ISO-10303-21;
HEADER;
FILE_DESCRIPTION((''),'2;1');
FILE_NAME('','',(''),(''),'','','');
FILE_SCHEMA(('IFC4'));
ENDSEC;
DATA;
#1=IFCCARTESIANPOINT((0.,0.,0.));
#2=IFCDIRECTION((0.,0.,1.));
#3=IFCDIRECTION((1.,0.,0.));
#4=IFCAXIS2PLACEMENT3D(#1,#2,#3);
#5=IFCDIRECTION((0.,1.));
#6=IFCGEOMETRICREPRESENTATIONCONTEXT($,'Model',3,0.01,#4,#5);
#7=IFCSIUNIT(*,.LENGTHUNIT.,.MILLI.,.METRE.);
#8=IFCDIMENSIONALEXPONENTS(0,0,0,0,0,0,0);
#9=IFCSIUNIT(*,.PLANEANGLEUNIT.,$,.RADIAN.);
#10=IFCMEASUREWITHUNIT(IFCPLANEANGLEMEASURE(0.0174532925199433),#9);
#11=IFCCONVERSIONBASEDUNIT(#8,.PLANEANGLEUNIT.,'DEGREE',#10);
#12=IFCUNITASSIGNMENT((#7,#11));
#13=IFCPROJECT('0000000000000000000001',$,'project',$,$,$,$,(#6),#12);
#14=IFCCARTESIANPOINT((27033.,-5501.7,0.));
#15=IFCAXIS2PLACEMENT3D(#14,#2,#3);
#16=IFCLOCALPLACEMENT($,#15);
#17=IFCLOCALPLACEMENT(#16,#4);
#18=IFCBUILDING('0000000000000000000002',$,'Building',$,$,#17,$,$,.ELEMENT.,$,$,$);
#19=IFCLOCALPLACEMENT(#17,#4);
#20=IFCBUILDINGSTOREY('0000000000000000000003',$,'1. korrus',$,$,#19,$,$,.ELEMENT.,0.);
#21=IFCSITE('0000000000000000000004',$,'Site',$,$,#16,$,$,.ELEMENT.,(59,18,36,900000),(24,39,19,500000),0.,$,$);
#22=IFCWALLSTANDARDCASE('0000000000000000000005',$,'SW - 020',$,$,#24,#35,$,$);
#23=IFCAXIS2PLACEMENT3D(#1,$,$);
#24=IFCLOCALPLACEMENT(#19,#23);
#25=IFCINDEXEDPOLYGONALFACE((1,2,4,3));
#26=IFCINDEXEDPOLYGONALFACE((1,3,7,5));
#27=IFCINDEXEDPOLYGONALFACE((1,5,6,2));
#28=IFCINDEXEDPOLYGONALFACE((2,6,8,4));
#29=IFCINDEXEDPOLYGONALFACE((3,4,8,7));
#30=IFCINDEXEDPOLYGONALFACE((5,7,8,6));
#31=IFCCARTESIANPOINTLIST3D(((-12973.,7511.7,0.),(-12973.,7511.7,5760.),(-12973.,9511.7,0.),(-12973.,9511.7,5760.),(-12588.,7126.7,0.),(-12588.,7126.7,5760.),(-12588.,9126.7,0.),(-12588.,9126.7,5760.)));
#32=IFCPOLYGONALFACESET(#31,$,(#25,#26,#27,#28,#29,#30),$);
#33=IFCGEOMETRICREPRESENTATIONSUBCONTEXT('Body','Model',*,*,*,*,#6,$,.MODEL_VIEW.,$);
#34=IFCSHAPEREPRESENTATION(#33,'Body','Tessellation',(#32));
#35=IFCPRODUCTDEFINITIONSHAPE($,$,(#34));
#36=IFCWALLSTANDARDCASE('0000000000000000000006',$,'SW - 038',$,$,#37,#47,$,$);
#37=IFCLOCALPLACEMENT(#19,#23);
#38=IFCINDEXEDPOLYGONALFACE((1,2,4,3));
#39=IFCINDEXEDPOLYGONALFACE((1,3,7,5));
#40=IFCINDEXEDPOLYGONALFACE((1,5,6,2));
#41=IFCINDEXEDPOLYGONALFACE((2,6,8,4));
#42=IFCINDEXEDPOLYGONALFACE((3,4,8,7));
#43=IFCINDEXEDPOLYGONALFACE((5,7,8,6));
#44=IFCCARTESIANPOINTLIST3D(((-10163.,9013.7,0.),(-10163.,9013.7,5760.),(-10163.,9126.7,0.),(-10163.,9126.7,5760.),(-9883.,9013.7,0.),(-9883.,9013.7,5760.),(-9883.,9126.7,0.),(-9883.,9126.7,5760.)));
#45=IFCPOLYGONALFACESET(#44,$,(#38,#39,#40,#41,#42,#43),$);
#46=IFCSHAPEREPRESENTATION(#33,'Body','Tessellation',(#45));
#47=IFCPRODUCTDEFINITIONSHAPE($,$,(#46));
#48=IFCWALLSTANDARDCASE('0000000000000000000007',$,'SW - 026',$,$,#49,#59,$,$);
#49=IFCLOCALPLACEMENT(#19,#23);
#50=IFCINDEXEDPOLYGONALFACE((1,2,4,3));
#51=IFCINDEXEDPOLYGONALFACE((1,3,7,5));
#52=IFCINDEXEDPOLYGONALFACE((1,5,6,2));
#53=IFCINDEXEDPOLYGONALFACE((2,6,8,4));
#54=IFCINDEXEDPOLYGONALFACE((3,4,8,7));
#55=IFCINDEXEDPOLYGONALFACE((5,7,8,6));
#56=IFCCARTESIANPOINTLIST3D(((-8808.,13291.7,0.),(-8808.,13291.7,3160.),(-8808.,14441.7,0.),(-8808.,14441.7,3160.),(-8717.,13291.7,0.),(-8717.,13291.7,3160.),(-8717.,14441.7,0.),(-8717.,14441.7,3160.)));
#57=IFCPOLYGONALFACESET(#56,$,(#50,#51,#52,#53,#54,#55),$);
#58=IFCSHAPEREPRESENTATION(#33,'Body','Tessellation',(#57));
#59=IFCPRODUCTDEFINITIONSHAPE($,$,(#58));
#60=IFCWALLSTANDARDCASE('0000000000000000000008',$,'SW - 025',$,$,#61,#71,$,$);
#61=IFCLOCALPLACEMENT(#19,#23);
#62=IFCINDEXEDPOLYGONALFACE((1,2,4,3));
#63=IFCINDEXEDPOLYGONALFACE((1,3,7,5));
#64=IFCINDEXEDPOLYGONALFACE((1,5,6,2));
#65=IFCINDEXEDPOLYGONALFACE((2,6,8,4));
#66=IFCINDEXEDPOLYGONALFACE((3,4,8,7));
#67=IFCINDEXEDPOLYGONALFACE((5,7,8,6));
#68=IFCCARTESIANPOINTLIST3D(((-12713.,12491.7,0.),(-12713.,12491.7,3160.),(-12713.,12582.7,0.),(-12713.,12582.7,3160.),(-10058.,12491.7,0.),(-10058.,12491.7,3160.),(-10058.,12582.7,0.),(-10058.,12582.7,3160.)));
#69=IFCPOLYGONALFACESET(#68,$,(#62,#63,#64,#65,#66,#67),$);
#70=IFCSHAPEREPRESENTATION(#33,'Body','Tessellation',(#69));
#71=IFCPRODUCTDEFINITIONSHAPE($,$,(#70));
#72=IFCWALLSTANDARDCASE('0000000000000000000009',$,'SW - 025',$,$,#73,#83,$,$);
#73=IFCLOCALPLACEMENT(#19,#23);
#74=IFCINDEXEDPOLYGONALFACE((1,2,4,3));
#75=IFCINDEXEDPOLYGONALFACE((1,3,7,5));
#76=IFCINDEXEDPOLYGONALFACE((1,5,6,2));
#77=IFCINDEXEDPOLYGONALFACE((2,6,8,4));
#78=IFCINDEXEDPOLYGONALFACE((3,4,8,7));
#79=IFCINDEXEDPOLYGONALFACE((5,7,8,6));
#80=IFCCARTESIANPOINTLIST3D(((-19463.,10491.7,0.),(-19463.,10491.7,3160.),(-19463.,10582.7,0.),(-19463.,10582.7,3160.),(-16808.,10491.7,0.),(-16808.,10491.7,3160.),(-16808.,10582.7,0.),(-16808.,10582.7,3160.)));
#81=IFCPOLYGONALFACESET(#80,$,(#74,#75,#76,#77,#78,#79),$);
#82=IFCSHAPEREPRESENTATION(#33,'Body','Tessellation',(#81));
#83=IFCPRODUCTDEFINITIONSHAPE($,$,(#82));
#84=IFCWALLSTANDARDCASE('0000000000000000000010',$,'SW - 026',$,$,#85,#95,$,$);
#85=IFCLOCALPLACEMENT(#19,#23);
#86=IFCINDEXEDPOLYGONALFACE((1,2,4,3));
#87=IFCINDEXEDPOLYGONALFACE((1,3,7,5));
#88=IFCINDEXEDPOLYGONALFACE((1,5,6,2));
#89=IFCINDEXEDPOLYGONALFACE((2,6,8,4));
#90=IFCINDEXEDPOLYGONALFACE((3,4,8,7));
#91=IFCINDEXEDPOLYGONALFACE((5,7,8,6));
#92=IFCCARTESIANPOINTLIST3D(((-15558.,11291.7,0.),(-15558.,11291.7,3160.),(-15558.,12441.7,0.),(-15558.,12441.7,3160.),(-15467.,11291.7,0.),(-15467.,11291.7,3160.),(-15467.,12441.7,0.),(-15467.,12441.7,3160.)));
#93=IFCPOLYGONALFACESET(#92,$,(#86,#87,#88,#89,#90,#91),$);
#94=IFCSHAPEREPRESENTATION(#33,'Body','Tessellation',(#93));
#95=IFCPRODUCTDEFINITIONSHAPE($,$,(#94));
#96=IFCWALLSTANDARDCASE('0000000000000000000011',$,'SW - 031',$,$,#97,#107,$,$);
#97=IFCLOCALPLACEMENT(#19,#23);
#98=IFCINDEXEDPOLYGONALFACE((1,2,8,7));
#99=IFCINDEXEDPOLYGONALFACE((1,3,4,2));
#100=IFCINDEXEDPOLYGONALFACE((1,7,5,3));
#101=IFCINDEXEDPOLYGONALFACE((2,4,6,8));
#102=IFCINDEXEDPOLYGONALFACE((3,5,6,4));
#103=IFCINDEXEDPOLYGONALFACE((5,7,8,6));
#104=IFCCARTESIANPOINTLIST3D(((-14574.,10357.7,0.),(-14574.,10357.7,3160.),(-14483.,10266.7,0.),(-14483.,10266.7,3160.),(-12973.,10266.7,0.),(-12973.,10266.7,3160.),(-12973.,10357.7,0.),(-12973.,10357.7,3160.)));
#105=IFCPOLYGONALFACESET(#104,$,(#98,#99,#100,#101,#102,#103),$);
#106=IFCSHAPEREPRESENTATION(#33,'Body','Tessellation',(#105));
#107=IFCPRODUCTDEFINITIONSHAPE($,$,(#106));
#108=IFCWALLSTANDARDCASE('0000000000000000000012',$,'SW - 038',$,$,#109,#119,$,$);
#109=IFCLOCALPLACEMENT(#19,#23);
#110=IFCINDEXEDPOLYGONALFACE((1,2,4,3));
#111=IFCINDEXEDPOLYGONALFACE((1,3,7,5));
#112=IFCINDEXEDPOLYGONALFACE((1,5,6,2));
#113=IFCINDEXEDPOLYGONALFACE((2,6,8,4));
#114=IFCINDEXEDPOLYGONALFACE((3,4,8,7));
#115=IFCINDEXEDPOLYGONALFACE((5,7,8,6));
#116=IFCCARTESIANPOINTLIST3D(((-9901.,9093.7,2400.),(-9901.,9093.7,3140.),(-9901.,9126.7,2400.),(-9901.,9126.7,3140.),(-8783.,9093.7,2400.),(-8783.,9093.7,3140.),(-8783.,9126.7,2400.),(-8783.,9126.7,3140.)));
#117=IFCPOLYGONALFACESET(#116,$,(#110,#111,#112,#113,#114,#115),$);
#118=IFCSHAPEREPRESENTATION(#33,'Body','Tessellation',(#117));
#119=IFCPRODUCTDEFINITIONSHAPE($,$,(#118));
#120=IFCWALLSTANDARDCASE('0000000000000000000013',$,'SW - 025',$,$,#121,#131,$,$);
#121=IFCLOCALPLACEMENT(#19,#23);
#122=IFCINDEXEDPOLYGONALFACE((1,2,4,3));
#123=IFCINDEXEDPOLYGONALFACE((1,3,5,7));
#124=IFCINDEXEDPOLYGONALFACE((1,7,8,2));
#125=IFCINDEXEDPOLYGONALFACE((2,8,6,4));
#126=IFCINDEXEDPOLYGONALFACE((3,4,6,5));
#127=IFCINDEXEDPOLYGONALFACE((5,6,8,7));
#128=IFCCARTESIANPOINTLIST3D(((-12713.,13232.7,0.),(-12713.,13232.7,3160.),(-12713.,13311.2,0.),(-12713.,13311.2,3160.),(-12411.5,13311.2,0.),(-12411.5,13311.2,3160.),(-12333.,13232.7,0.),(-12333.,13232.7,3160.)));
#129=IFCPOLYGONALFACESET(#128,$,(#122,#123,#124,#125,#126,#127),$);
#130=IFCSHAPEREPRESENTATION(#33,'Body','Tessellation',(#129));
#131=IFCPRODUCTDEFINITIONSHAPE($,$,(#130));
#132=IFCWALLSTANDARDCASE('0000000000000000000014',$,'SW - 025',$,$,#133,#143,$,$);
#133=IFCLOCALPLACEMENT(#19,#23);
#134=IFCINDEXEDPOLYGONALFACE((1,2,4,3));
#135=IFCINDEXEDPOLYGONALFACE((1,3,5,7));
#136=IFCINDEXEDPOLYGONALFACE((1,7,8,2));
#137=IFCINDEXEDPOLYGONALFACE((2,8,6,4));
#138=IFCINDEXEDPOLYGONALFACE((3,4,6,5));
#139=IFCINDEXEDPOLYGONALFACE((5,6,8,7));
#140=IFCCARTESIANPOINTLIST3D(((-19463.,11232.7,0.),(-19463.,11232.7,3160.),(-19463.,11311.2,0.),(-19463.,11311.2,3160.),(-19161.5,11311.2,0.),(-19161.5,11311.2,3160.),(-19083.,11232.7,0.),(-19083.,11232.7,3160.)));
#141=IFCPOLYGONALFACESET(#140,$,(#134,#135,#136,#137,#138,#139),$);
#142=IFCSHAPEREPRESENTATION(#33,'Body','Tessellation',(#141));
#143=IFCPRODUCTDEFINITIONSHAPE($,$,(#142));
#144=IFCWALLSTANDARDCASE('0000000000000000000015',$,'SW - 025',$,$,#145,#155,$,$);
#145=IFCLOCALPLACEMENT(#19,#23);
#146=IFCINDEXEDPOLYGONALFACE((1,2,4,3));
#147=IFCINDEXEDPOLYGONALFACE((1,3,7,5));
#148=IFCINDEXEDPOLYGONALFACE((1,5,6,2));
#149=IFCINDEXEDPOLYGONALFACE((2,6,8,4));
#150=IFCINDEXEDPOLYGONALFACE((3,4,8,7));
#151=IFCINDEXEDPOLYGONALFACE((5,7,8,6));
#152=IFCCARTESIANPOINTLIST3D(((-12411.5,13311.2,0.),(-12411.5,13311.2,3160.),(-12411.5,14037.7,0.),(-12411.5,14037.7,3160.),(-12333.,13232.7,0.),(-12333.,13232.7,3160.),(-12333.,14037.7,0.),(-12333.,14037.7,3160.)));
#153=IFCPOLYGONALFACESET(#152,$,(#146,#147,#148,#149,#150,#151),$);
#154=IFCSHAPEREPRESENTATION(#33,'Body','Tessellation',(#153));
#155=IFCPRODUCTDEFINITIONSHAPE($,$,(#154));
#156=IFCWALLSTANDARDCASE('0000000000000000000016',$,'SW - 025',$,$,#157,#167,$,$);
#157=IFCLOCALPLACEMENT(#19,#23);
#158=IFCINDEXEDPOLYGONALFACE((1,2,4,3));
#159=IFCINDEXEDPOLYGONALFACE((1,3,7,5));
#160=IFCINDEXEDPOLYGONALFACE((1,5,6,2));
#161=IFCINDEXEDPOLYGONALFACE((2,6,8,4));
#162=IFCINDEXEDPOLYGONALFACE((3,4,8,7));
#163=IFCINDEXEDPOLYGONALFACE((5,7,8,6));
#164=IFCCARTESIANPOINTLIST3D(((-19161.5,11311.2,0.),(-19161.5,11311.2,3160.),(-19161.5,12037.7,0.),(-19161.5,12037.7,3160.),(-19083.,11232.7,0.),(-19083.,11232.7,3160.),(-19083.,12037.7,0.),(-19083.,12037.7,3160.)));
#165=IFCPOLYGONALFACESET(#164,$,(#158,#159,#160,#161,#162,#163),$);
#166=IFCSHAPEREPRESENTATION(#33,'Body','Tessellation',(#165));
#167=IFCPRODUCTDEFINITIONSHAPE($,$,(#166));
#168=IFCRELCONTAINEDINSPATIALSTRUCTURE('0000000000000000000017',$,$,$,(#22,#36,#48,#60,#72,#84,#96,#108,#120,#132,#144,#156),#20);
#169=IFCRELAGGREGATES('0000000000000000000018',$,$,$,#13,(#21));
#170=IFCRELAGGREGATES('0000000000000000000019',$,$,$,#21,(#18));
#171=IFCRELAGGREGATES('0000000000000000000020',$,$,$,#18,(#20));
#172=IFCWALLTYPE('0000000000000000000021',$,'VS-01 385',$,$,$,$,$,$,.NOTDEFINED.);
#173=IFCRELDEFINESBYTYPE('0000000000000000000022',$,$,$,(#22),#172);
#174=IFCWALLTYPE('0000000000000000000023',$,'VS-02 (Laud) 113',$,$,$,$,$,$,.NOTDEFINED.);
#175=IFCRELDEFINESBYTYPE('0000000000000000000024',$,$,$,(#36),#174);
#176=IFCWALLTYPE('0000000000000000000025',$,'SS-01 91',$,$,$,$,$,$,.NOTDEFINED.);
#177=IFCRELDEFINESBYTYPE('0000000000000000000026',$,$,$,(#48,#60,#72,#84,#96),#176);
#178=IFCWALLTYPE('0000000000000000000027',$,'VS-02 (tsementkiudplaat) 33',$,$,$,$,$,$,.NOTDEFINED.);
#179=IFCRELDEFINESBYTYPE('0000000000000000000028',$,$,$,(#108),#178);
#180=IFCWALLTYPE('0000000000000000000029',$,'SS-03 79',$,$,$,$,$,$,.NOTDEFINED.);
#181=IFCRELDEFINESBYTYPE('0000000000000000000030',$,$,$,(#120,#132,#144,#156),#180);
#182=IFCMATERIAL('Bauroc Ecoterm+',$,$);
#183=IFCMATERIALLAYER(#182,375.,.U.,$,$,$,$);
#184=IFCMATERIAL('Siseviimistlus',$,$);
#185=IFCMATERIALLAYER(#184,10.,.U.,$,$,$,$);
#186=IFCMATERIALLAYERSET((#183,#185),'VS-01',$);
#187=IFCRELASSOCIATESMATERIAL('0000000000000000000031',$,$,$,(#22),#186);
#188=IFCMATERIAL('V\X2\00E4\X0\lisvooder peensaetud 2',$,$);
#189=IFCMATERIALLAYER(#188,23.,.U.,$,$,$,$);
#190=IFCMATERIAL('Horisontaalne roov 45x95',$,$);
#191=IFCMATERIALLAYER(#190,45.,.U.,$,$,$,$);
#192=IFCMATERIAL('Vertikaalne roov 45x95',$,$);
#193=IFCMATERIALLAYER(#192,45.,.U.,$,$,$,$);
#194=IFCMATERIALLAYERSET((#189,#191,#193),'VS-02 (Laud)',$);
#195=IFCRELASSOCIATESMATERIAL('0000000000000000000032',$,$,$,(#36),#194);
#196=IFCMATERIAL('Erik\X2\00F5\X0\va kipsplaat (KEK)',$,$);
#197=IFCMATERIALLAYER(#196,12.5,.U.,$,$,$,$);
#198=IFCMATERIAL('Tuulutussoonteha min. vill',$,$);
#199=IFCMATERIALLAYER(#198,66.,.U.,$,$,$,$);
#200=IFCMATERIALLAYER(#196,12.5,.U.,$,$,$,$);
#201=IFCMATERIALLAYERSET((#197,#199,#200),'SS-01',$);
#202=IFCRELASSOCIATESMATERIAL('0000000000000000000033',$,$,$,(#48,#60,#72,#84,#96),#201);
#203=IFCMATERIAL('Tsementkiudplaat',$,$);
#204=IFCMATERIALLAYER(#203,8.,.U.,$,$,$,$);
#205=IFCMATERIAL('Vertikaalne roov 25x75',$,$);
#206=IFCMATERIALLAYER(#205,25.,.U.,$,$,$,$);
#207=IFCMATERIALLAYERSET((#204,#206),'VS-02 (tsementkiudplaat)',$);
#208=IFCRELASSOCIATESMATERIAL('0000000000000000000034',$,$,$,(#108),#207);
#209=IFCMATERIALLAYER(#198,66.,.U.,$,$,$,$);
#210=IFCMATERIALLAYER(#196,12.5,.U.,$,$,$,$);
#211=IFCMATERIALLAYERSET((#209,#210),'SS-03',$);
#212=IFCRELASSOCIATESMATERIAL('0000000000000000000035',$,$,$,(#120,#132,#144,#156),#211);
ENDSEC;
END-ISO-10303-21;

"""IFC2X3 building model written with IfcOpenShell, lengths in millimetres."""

from ifc_helpers import new_model, entity, si_unit, converted_unit, direction, frame, origin_with_axes, origin_2d_with_axis, place, context, subcontext, project, spatial, polyline, rectangle, outline, extrude, material, layer, layer_set, layer_usage, type_object, element, save


model = new_model("IFC2X3")

# Units and contexts
model_context = context("Model", 3, precision=0.01, world=origin_with_axes(), true_north=direction((0.0, 1.0)))
body_context = subcontext(model_context, "Body", "Model", "MODEL_VIEW")
ifc_project = project(units=[si_unit("LENGTHUNIT", "METRE", prefix="MILLI"), converted_unit("PLANEANGLEUNIT", "DEGREE", entity("IfcPlaneAngleMeasure", 0.0174532925199433), si_unit("PLANEANGLEUNIT", "RADIAN"), dimensions=[0, 0, 0, 0, 0, 0, 0])], contexts=[model_context])

# Site, building, storey
site_placement = place(None, frame((27033.0, -5501.7, 0.0), z_axis=(0.0, 0.0, 1.0), x_axis=(1.0, 0.0, 0.0)))
site = spatial("IfcSite", under=ifc_project, at=site_placement, Name="Site", CompositionType="ELEMENT", RefLatitude=(59, 18, 36, 900000), RefLongitude=(24, 39, 19, 500000), RefElevation=0.0)
building_placement = place(site_placement, origin_with_axes())
building = spatial("IfcBuilding", under=site, at=building_placement, Name="Building", CompositionType="ELEMENT")
storey_placement = place(building_placement, origin_with_axes())
storey = spatial("IfcBuildingStorey", under=building, at=storey_placement, Name="1. korrus", CompositionType="ELEMENT", Elevation=0.0)

# Walls
ifc_material_1 = material(Name="Bauroc Ecoterm+")
ifc_layer_1 = layer(ifc_material_1, 375.0, ventilated="UNKNOWN")
ifc_material_2 = material(Name="Siseviimistlus")
ifc_layer_2 = layer(ifc_material_2, 10.0, ventilated="UNKNOWN")
ifc_layer_set_1 = layer_set([ifc_layer_1, ifc_layer_2], Name="VS-01")
ifc_layer_usage_1 = layer_usage(ifc_layer_set_1, "AXIS2", "NEGATIVE", 385.0)
wall_type_1 = type_object("IfcWallType", Name="VS-01 385", PredefinedType="NOTDEFINED")
wall_1_placement = place(storey_placement, frame((-12973.0, 9511.7, 0.0), z_axis=(0.0, 0.0, 1.0), x_axis=(0.0, -1.0, 0.0)))
element("IfcWallStandardCase", 1, at=wall_1_placement, inside=storey, type_object=wall_type_1, material=ifc_layer_usage_1, Name="SW - 020", context=body_context, shape_type="SweptSolid", body=[
    extrude(outline(polyline([(0.0, 0.0), (2000.0, 0.0), (2385.0, 385.0), (385.0, 385.0), (0.0, 0.0)])), origin_with_axes(), (0.0, 0.0, 1.0), 5760.0),
])
ifc_material_3 = material(Name="Välisvooder peensaetud 2")
ifc_layer_3 = layer(ifc_material_3, 23.0, ventilated="UNKNOWN")
ifc_material_4 = material(Name="Horisontaalne roov 45x95")
ifc_layer_4 = layer(ifc_material_4, 45.0, ventilated="UNKNOWN")
ifc_material_5 = material(Name="Vertikaalne roov 45x95")
ifc_layer_5 = layer(ifc_material_5, 45.0, ventilated="UNKNOWN")
ifc_layer_set_2 = layer_set([ifc_layer_3, ifc_layer_4, ifc_layer_5], Name="VS-02 (Laud)")
wall_type_2 = type_object("IfcWallType", Name="VS-02 (Laud) 113", PredefinedType="NOTDEFINED")
ifc_layer_usage_2 = layer_usage(ifc_layer_set_2, "AXIS2", "POSITIVE", -113.0)
wall_2_placement = place(storey_placement, frame((-10163.0, 9126.7, 0.0), z_axis=(0.0, 0.0, 1.0), x_axis=(1.0, 0.0, 0.0)))
element("IfcWallStandardCase", 2, at=wall_2_placement, inside=storey, type_object=wall_type_2, material=ifc_layer_usage_2, Name="SW - 038", context=body_context, shape_type="SweptSolid", body=[
    extrude(outline(polyline([(0.0, -113.0), (280.0, -113.0), (280.0, 0.0), (0.0, 0.0), (0.0, -113.0)])), origin_with_axes(), (0.0, 0.0, 1.0), 5760.0),
])
ifc_material_6 = material(Name="Erikõva kipsplaat (KEK)")
ifc_layer_6 = layer(ifc_material_6, 12.5, ventilated="UNKNOWN")
ifc_material_7 = material(Name="Tuulutussoonteha min. vill")
ifc_layer_7 = layer(ifc_material_7, 66.0, ventilated="UNKNOWN")
ifc_layer_8 = layer(ifc_material_6, 12.5, ventilated="UNKNOWN")
ifc_layer_set_3 = layer_set([ifc_layer_6, ifc_layer_7, ifc_layer_8], Name="SS-01")
ifc_layer_usage_3 = layer_usage(ifc_layer_set_3, "AXIS2", "POSITIVE", -91.0)
wall_type_3 = type_object("IfcWallType", Name="SS-01 91", PredefinedType="NOTDEFINED")
wall_3_placement = place(storey_placement, frame((-8808.0, 13291.7, 0.0), z_axis=(0.0, 0.0, 1.0), x_axis=(0.0, 1.0, 0.0)))
element("IfcWallStandardCase", 3, at=wall_3_placement, inside=storey, type_object=wall_type_3, material=ifc_layer_usage_3, Name="SW - 026", context=body_context, shape_type="SweptSolid", body=[
    extrude(outline(polyline([(0.0, -91.0), (1150.0, -91.0), (1150.0, 0.0), (0.0, 0.0), (0.0, -91.0)])), origin_with_axes(), (0.0, 0.0, 1.0), 3160.0),
])
ifc_layer_usage_4 = layer_usage(ifc_layer_set_3, "AXIS2", "NEGATIVE", 91.0)
wall_4_placement = place(storey_placement, frame((-12713.0, 12491.7, 0.0), z_axis=(0.0, 0.0, 1.0), x_axis=(1.0, 0.0, 0.0)))
element("IfcWallStandardCase", 4, at=wall_4_placement, inside=storey, type_object=wall_type_3, material=ifc_layer_usage_4, Name="SW - 025", context=body_context, shape_type="SweptSolid", body=[
    extrude(outline(polyline([(0.0, 0.0), (2655.0, 0.0), (2655.0, 91.0), (0.0, 91.0), (0.0, 0.0)])), origin_with_axes(), (0.0, 0.0, 1.0), 3160.0),
])

# Walls
ifc_layer_usage_5 = layer_usage(ifc_layer_set_3, "AXIS2", "NEGATIVE", 91.0)
wall_5_placement = place(storey_placement, frame((-19463.0, 10491.7, 0.0), z_axis=(0.0, 0.0, 1.0), x_axis=(1.0, 0.0, 0.0)))
element("IfcWallStandardCase", 5, at=wall_5_placement, inside=storey, type_object=wall_type_3, material=ifc_layer_usage_5, Name="SW - 025", context=body_context, shape_type="SweptSolid", body=[
    extrude(outline(polyline([(0.0, 0.0), (2655.0, 0.0), (2655.0, 91.0), (0.0, 91.0), (0.0, 0.0)])), origin_with_axes(), (0.0, 0.0, 1.0), 3160.0),
])
ifc_layer_usage_6 = layer_usage(ifc_layer_set_3, "AXIS2", "POSITIVE", -91.0)
wall_6_placement = place(storey_placement, frame((-15558.0, 11291.7, 0.0), z_axis=(0.0, 0.0, 1.0), x_axis=(0.0, 1.0, 0.0)))
element("IfcWallStandardCase", 6, at=wall_6_placement, inside=storey, type_object=wall_type_3, material=ifc_layer_usage_6, Name="SW - 026", context=body_context, shape_type="SweptSolid", body=[
    extrude(outline(polyline([(0.0, -91.0), (1150.0, -91.0), (1150.0, 0.0), (0.0, 0.0), (0.0, -91.0)])), origin_with_axes(), (0.0, 0.0, 1.0), 3160.0),
])
ifc_layer_usage_7 = layer_usage(ifc_layer_set_3, "AXIS2", "NEGATIVE", 91.0)
wall_7_placement = place(storey_placement, frame((-12973.0, 10357.7, 0.0), z_axis=(0.0, 0.0, 1.0), x_axis=(-1.0, 0.0, 0.0)))
element("IfcWallStandardCase", 7, at=wall_7_placement, inside=storey, type_object=wall_type_3, material=ifc_layer_usage_7, Name="SW - 031", context=body_context, shape_type="SweptSolid", body=[
    extrude(outline(polyline([(0.0, 0.0), (1601.0, 0.0), (1510.0, 91.0), (0.0, 91.0), (0.0, 0.0)])), origin_with_axes(), (0.0, 0.0, 1.0), 3160.0),
])

# Shared definitions
ifc_material_8 = material(Name="Tsementkiudplaat")
ifc_layer_9 = layer(ifc_material_8, 8.0, ventilated="UNKNOWN")
ifc_material_9 = material(Name="Vertikaalne roov 25x75")
ifc_layer_10 = layer(ifc_material_9, 25.0, ventilated="UNKNOWN")
ifc_layer_set_4 = layer_set([ifc_layer_9, ifc_layer_10], Name="VS-02 (tsementkiudplaat)")
wall_type_4 = type_object("IfcWallType", Name="VS-02 (tsementkiudplaat) 33", PredefinedType="NOTDEFINED")

# Wall, opening
ifc_layer_usage_8 = layer_usage(ifc_layer_set_4, "AXIS2", "POSITIVE", -33.0)
wall_8_placement = place(storey_placement, frame((-9901.0, 9126.7, 2400.0), z_axis=(0.0, 0.0, 1.0), x_axis=(1.0, 0.0, 0.0)))
wall_8 = element("IfcWallStandardCase", 8, at=wall_8_placement, inside=storey, type_object=wall_type_4, material=ifc_layer_usage_8, Name="SW - 038", context=body_context, shape_type="SweptSolid", body=[
    extrude(outline(polyline([(0.0, -33.0), (1118.0, -33.0), (1118.0, 0.0), (0.0, 0.0), (0.0, -33.0)])), origin_with_axes(), (0.0, 0.0, 1.0), 740.0),
])
opening_1_placement = place(wall_8_placement, frame((550.0, 0.0, -2400.0), z_axis=(0.0, 0.0, 1.0), x_axis=(1.0, 0.0, 0.0)))
element("IfcOpeningElement", 9, at=opening_1_placement, cuts=wall_8, context=body_context, shape_type="SweptSolid", body=[
    extrude(rectangle(XDim=1100.0, YDim=2400.0, at=origin_2d_with_axis()), frame((0.0, 33.0, 1200.0), z_axis=(0.0, 1.0, 0.0), x_axis=(-1.0, 0.0, 0.0)), (0.0, 0.0, -1.0), 99.0),
])

# Walls
ifc_layer_11 = layer(ifc_material_7, 66.0, ventilated="UNKNOWN")
ifc_layer_12 = layer(ifc_material_6, 12.5, ventilated="UNKNOWN")
ifc_layer_set_5 = layer_set([ifc_layer_11, ifc_layer_12], Name="SS-03")
ifc_layer_usage_9 = layer_usage(ifc_layer_set_5, "AXIS2", "POSITIVE", -78.5)
wall_type_5 = type_object("IfcWallType", Name="SS-03 79", PredefinedType="NOTDEFINED")
wall_9_placement = place(storey_placement, frame((-12333.0, 13232.7, 0.0), z_axis=(0.0, 0.0, 1.0), x_axis=(-1.0, 0.0, 0.0)))
element("IfcWallStandardCase", 10, at=wall_9_placement, inside=storey, type_object=wall_type_5, material=ifc_layer_usage_9, Name="SW - 025", context=body_context, shape_type="SweptSolid", body=[
    extrude(outline(polyline([(78.5, -78.5), (380.0, -78.5), (380.0, 0.0), (0.0, 0.0), (78.5, -78.5)])), origin_with_axes(), (0.0, 0.0, 1.0), 3160.0),
])
ifc_layer_usage_10 = layer_usage(ifc_layer_set_5, "AXIS2", "POSITIVE", -78.5)
wall_10_placement = place(storey_placement, frame((-19083.0, 11232.7, 0.0), z_axis=(0.0, 0.0, 1.0), x_axis=(-1.0, 0.0, 0.0)))
element("IfcWallStandardCase", 11, at=wall_10_placement, inside=storey, type_object=wall_type_5, material=ifc_layer_usage_10, Name="SW - 025", context=body_context, shape_type="SweptSolid", body=[
    extrude(outline(polyline([(78.5, -78.5), (380.0, -78.5), (380.0, 0.0), (0.0, 0.0), (78.5, -78.5)])), origin_with_axes(), (0.0, 0.0, 1.0), 3160.0),
])
ifc_layer_usage_11 = layer_usage(ifc_layer_set_5, "AXIS2", "NEGATIVE", 78.5)
wall_11_placement = place(storey_placement, frame((-12333.0, 13232.7, 0.0), z_axis=(0.0, 0.0, 1.0), x_axis=(0.0, 1.0, 0.0)))
element("IfcWallStandardCase", 12, at=wall_11_placement, inside=storey, type_object=wall_type_5, material=ifc_layer_usage_11, Name="SW - 025", context=body_context, shape_type="SweptSolid", body=[
    extrude(outline(polyline([(0.0, 0.0), (805.0, 0.0), (805.0, 78.5), (78.5, 78.5), (0.0, 0.0)])), origin_with_axes(), (0.0, 0.0, 1.0), 3160.0),
])
ifc_layer_usage_12 = layer_usage(ifc_layer_set_5, "AXIS2", "NEGATIVE", 78.5)
wall_12_placement = place(storey_placement, frame((-19083.0, 11232.7, 0.0), z_axis=(0.0, 0.0, 1.0), x_axis=(0.0, 1.0, 0.0)))
element("IfcWallStandardCase", 13, at=wall_12_placement, inside=storey, type_object=wall_type_5, material=ifc_layer_usage_12, Name="SW - 025", context=body_context, shape_type="SweptSolid", body=[
    extrude(outline(polyline([(0.0, 0.0), (805.0, 0.0), (805.0, 78.5), (78.5, 78.5), (0.0, 0.0)])), origin_with_axes(), (0.0, 0.0, 1.0), 3160.0),
])

save(model, "model.ifc")
